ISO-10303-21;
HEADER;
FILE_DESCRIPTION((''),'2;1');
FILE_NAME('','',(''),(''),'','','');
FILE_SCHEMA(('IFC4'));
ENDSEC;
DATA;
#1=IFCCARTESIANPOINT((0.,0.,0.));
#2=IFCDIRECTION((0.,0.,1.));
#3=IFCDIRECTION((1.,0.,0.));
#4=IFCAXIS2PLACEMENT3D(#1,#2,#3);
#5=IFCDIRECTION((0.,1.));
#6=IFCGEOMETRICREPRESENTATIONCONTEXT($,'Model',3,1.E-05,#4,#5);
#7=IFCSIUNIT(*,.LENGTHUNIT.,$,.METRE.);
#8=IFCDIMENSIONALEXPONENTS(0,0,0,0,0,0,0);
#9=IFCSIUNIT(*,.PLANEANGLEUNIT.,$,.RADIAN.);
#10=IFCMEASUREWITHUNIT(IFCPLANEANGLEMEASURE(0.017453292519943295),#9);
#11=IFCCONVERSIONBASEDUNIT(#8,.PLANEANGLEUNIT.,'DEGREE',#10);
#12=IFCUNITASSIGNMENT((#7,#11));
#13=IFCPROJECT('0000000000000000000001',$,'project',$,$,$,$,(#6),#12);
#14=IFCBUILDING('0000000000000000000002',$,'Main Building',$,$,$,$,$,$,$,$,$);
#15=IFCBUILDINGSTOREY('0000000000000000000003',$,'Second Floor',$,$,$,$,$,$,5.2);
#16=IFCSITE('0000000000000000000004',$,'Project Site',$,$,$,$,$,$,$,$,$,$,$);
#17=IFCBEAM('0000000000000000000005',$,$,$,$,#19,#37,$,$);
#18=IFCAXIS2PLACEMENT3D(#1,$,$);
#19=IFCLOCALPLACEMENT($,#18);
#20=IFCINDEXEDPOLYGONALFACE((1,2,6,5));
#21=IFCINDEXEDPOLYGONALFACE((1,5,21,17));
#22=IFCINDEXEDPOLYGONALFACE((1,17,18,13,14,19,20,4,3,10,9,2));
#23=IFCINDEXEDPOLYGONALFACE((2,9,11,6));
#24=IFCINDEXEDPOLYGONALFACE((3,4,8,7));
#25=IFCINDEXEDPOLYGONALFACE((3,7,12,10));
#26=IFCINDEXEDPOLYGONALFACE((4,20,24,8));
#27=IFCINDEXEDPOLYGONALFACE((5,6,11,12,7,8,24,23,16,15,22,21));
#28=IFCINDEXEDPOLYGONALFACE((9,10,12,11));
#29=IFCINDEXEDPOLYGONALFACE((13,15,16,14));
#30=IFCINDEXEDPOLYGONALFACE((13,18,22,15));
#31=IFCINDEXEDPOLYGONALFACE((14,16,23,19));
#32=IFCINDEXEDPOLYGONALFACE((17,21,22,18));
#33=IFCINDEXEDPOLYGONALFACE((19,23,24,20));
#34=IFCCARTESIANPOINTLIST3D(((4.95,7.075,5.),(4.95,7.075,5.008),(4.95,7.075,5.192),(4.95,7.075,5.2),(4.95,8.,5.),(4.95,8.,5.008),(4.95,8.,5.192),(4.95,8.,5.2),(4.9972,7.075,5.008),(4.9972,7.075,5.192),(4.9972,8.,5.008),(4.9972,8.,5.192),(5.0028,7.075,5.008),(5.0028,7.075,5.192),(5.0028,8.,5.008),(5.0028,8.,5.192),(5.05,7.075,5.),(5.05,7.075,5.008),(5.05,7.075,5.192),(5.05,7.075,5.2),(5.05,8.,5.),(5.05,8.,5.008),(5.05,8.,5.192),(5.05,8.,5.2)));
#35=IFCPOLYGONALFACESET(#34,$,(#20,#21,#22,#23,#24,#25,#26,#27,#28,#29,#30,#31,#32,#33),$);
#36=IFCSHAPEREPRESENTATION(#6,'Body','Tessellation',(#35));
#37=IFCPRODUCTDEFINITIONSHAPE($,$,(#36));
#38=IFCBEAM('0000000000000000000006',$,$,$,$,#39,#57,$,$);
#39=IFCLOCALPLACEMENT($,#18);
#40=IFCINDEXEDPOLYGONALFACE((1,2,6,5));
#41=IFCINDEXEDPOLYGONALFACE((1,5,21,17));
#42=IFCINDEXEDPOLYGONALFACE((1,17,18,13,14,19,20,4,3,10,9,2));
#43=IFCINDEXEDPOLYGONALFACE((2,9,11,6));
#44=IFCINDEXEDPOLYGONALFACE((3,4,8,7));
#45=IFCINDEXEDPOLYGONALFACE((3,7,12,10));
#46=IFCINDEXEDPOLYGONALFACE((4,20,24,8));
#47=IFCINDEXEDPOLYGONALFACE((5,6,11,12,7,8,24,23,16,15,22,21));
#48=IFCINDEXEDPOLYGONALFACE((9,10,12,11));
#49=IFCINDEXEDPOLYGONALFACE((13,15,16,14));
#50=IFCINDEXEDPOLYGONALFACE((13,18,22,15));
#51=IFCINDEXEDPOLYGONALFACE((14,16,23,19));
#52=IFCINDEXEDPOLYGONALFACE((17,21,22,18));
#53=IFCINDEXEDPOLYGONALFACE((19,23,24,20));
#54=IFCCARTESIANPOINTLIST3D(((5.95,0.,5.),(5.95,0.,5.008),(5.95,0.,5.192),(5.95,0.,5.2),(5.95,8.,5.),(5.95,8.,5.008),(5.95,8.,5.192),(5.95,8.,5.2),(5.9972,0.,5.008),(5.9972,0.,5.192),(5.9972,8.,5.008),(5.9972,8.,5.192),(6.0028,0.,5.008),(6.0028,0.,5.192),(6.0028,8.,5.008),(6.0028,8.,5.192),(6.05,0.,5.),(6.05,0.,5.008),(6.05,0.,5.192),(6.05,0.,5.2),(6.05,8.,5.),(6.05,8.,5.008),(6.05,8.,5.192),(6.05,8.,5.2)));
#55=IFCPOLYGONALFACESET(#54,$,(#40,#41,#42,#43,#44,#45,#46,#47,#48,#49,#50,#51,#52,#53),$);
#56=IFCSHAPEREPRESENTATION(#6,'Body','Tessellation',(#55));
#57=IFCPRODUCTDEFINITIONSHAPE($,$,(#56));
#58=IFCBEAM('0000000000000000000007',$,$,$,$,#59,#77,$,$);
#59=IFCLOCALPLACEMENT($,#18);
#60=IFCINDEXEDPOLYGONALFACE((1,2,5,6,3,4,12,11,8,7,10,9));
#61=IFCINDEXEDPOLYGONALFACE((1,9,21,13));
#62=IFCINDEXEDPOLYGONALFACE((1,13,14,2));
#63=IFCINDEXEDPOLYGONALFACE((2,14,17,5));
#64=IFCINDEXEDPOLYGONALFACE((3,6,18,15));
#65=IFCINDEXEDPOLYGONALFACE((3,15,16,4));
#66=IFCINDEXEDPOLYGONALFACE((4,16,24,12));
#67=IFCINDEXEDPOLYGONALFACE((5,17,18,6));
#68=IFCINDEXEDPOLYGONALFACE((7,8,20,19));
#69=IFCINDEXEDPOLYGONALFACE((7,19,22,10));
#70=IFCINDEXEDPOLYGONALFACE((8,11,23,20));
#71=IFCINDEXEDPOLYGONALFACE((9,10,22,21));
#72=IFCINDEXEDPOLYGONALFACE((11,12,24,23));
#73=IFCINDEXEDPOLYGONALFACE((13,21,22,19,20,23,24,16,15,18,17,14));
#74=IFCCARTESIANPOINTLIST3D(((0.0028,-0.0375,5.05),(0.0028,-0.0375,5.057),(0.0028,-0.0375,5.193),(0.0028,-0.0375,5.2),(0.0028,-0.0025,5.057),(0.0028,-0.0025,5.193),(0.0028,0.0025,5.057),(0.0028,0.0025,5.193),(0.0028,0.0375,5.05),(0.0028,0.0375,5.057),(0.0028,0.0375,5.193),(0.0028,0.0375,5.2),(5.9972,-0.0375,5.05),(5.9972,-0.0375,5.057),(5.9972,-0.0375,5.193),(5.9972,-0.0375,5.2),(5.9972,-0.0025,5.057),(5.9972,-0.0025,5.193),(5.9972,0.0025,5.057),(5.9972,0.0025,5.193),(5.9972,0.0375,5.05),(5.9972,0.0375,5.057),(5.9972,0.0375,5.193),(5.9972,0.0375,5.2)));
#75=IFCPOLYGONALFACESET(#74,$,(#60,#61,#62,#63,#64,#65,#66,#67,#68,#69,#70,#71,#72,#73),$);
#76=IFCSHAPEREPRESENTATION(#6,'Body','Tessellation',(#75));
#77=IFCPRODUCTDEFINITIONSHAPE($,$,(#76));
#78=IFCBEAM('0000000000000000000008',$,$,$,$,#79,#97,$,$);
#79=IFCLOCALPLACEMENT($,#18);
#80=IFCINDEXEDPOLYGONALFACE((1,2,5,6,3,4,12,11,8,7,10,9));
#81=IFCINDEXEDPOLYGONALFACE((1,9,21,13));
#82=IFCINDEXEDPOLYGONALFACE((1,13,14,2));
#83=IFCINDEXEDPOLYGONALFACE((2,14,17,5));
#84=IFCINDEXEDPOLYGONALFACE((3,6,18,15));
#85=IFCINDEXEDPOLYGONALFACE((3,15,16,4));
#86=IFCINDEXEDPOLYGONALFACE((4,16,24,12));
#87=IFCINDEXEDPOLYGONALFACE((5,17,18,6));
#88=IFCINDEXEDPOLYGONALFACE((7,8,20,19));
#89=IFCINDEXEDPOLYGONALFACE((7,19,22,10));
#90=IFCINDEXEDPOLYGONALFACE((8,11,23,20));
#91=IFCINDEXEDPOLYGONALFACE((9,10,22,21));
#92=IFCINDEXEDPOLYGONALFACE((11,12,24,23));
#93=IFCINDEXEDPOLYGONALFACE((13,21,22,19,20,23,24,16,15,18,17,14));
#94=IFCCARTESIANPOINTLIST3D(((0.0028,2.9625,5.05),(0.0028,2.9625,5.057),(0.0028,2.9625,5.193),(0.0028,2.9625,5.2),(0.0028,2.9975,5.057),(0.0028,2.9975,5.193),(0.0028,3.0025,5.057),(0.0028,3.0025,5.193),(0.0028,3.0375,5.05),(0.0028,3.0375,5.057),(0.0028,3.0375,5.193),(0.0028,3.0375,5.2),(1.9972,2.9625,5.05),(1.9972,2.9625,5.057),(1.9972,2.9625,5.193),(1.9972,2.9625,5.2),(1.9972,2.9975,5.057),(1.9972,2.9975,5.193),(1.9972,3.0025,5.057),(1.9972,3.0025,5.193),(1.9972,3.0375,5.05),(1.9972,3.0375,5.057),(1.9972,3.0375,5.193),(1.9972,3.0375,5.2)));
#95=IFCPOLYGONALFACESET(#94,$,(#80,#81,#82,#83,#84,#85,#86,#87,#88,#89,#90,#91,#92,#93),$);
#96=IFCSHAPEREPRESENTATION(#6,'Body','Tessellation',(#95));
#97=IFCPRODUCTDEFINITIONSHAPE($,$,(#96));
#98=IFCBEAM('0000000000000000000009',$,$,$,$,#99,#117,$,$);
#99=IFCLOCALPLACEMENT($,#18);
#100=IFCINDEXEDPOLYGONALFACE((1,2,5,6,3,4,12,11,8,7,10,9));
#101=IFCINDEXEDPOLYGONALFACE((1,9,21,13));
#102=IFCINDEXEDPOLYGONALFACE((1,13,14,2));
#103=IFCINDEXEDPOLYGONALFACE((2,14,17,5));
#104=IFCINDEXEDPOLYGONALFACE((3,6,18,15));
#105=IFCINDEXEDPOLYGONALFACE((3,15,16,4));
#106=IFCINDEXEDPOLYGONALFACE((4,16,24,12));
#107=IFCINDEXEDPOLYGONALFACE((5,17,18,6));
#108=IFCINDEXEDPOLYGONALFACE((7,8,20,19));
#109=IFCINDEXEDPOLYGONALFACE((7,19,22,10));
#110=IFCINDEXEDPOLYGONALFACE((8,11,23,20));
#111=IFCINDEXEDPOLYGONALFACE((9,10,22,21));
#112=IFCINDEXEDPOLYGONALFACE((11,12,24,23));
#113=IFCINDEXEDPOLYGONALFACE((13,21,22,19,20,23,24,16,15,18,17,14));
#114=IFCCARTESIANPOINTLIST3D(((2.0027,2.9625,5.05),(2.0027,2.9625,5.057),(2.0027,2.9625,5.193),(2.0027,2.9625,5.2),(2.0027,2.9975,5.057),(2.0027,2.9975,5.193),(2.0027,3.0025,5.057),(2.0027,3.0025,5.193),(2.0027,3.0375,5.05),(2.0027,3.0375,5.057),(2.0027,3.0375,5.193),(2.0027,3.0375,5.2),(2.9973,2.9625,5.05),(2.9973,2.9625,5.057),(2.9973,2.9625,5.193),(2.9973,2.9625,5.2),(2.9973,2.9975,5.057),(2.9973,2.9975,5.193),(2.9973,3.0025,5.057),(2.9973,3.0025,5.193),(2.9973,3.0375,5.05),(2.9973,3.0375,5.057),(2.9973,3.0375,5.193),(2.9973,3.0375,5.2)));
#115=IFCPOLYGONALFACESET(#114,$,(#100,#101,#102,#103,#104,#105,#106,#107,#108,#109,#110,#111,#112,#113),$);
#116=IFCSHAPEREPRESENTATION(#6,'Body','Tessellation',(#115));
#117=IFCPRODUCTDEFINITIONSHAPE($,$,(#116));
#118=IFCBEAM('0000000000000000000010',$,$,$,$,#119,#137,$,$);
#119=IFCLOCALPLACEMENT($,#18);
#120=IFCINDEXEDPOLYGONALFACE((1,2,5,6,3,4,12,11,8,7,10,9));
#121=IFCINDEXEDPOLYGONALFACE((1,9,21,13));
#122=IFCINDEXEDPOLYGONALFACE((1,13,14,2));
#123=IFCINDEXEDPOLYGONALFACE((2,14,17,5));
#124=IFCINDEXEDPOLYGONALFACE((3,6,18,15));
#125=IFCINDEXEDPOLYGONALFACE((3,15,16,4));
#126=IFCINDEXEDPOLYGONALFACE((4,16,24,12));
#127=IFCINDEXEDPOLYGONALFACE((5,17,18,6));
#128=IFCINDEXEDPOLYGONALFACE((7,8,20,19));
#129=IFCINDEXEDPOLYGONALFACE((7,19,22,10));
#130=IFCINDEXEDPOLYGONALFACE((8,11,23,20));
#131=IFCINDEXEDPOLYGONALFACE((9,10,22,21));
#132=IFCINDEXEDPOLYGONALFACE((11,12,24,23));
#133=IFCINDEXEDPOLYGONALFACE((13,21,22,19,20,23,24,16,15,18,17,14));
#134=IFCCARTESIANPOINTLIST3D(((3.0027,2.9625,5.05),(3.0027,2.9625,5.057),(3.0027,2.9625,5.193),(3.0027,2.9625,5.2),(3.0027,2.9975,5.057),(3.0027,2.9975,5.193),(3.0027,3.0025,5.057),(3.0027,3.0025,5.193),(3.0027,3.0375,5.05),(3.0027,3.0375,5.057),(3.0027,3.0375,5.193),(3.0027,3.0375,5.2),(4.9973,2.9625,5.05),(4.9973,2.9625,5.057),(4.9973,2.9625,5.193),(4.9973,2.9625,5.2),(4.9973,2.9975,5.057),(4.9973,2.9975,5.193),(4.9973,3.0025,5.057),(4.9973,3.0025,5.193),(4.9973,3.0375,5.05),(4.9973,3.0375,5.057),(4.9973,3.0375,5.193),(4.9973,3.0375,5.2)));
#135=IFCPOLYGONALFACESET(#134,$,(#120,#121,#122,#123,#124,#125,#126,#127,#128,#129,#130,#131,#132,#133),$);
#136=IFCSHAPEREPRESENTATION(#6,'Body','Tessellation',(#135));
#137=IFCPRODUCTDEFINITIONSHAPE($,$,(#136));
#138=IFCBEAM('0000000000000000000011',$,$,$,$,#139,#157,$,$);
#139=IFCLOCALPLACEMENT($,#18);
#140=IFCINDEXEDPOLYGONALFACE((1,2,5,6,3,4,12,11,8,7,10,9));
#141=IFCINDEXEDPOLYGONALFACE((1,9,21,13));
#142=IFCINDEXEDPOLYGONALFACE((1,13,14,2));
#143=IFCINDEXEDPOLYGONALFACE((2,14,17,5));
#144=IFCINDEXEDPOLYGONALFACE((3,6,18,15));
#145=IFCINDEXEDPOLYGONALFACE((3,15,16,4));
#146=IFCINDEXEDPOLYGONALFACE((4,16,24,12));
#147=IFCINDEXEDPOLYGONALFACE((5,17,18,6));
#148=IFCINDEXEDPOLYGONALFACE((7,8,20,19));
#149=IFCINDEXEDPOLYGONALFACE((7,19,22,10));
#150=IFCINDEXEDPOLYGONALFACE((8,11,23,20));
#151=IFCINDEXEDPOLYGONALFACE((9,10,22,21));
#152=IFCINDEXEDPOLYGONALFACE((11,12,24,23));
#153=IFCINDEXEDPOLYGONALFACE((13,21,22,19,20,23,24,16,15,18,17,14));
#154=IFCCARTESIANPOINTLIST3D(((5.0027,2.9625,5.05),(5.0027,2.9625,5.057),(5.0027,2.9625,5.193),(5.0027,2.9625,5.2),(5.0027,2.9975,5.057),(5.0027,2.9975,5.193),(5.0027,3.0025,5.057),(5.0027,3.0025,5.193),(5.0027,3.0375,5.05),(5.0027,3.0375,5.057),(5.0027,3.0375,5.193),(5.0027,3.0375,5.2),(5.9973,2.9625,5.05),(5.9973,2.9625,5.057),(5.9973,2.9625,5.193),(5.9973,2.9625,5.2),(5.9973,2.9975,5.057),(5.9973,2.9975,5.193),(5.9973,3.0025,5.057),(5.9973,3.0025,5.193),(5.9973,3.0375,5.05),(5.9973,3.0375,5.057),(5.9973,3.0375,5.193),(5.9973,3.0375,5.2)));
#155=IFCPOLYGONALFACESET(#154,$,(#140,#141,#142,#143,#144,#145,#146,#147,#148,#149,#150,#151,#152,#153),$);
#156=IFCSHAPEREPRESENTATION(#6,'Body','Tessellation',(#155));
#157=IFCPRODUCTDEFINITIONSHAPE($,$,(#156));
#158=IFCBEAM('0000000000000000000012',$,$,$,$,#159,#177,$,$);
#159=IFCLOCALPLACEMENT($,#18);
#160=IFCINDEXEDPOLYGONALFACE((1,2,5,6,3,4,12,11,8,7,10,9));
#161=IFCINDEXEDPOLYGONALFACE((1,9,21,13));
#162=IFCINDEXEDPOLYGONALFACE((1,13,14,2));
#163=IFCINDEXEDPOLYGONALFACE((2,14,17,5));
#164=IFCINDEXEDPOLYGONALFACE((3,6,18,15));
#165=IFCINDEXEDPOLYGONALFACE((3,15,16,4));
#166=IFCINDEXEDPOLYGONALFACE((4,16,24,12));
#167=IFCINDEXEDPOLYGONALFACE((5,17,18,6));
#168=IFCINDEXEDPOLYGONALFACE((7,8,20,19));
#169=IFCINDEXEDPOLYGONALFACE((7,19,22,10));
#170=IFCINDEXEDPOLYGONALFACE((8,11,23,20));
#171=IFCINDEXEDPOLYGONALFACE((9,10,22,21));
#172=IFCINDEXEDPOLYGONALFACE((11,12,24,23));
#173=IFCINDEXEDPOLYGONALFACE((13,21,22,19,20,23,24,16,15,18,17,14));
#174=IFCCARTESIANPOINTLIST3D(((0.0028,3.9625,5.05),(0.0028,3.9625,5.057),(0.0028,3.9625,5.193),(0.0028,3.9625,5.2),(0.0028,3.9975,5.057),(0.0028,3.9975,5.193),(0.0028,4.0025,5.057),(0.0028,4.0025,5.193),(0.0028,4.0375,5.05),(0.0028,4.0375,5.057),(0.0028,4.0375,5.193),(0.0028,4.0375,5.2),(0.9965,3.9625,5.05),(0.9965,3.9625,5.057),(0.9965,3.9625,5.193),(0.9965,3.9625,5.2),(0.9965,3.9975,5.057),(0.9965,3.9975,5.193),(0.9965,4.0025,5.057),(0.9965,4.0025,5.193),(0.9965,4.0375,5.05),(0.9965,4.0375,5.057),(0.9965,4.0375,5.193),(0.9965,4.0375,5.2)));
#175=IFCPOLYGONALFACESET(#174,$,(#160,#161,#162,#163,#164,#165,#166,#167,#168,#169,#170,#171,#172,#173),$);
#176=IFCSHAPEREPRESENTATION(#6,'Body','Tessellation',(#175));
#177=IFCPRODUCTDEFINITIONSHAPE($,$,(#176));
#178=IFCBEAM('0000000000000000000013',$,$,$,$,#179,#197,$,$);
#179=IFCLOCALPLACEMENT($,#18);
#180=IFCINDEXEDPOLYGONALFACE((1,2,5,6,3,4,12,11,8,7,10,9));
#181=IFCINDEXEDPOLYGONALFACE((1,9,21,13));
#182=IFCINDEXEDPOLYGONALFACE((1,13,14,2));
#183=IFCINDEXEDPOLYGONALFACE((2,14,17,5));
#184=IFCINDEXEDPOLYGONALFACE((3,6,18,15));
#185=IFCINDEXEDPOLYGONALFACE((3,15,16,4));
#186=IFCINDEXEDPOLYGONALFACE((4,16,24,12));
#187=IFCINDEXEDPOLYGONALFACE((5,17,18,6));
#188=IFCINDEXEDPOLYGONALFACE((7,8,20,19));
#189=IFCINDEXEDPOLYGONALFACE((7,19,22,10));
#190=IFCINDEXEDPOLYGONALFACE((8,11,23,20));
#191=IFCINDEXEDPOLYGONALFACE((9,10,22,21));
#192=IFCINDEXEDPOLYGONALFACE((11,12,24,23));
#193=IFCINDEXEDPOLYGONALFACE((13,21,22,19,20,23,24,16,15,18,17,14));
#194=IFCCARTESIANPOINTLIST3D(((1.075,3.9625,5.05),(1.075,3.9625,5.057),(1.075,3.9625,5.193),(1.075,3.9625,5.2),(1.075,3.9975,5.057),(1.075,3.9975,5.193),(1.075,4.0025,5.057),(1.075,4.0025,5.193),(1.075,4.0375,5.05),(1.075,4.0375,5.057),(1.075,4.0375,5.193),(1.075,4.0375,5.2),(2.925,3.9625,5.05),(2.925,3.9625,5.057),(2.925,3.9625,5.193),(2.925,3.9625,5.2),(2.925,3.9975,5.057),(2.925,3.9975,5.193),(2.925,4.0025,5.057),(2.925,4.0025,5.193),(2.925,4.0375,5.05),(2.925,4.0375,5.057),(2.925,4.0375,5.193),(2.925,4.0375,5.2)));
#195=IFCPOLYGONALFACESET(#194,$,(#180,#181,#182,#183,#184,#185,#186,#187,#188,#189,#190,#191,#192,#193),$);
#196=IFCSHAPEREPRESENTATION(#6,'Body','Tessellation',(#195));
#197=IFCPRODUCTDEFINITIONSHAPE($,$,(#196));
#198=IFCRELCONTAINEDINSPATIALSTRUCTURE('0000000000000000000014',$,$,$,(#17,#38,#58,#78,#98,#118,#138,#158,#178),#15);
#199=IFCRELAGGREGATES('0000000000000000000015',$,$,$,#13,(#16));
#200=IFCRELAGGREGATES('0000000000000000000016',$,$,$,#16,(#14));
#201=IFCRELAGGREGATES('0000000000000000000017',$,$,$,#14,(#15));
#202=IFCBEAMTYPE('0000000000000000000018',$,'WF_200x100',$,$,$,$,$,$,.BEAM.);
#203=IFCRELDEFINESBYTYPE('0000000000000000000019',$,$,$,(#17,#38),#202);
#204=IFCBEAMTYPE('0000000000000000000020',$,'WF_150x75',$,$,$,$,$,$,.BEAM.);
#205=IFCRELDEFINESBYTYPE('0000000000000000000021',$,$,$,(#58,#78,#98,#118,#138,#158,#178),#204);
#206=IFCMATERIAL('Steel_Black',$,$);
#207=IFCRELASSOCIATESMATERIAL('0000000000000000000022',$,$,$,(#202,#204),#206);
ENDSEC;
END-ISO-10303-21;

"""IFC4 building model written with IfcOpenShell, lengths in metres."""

from ifc_helpers import new_model, entity, si_unit, converted_unit, direction, frame, frame_2d, origin_with_axes, origin_2d, place, context, project, spatial, i_section, extrude, material, material_profile, profile_set, type_object, element, save


model = new_model("IFC4")

# Units and contexts
model_context = context("Model", 3, precision=1e-05, world=origin_with_axes(), true_north=direction((0.0, 1.0)))
ifc_project = project(units=[si_unit("LENGTHUNIT", "METRE"), converted_unit("PLANEANGLEUNIT", "DEGREE", entity("IfcPlaneAngleMeasure", 0.017453292519943295), si_unit("PLANEANGLEUNIT", "RADIAN"), dimensions=[0, 0, 0, 0, 0, 0, 0])], contexts=[model_context])

# Site, building, storey
site = spatial("IfcSite", under=ifc_project, Name="Project Site")
building = spatial("IfcBuilding", under=site, Name="Main Building")
storey = spatial("IfcBuildingStorey", under=building, Name="Second Floor", Elevation=5.2)

# Beams
ifc_material = material(Name="Steel_Black")
ifc_material_profile_1 = material_profile(ifc_material, i_section(OverallWidth=0.1, OverallDepth=0.2, WebThickness=0.0055, FlangeThickness=0.008, at=origin_2d()), Name="WF_200x100")
ifc_profile_set_1 = profile_set([ifc_material_profile_1], Name="WF_200x100")
beam_type_1 = type_object("IfcBeamType", Name="WF_200x100", PredefinedType="BEAM", material=ifc_profile_set_1)
beam_1_placement = place(None, frame((5.0, 7.075, 5.0), z_axis=(0.0, 0.0, 1.0), x_axis=(0.0, 1.0, 0.0)))
element("IfcBeam", 1, at=beam_1_placement, inside=storey, type_object=beam_type_1, context=model_context, shape_type="SweptSolid", body=[
    extrude(i_section(OverallWidth=0.1, OverallDepth=0.2, WebThickness=0.0055, FlangeThickness=0.008, at=frame_2d((0.0, 0.1))), frame((0.0, 0.0, 0.0), z_axis=(1.0, 0.0, 0.0), x_axis=(0.0, 1.0, 0.0)), (0.0, 0.0, 1.0), 0.925),
])
beam_2_placement = place(None, frame((6.0, 0.0, 5.0), z_axis=(0.0, 0.0, 1.0), x_axis=(0.0, 1.0, 0.0)))
element("IfcBeam", 2, at=beam_2_placement, inside=storey, type_object=beam_type_1, context=model_context, shape_type="SweptSolid", body=[
    extrude(i_section(OverallWidth=0.1, OverallDepth=0.2, WebThickness=0.0055, FlangeThickness=0.008, at=frame_2d((0.0, 0.1))), frame((0.0, 0.0, 0.0), z_axis=(1.0, 0.0, 0.0), x_axis=(0.0, 1.0, 0.0)), (0.0, 0.0, 1.0), 8.0),
])
ifc_material_profile_2 = material_profile(ifc_material, i_section(OverallWidth=0.075, OverallDepth=0.15, WebThickness=0.005, FlangeThickness=0.007, at=origin_2d()), Name="WF_150x75")
ifc_profile_set_2 = profile_set([ifc_material_profile_2], Name="WF_150x75")
beam_type_2 = type_object("IfcBeamType", Name="WF_150x75", PredefinedType="BEAM", material=ifc_profile_set_2)
beam_3_placement = place(None, frame((0.0027, 0.0, 5.05), z_axis=(0.0, 0.0, 1.0), x_axis=(1.0, 0.0, 0.0)))
element("IfcBeam", 3, at=beam_3_placement, inside=storey, type_object=beam_type_2, context=model_context, shape_type="SweptSolid", body=[
    extrude(i_section(OverallWidth=0.075, OverallDepth=0.15, WebThickness=0.005, FlangeThickness=0.007, at=frame_2d((0.0, 0.075))), frame((0.0, 0.0, 0.0), z_axis=(1.0, 0.0, 0.0), x_axis=(0.0, 1.0, 0.0)), (0.0, 0.0, 1.0), 5.9945),
])
beam_4_placement = place(None, frame((0.0027, 3.0, 5.05), z_axis=(0.0, 0.0, 1.0), x_axis=(1.0, 0.0, 0.0)))
element("IfcBeam", 4, at=beam_4_placement, inside=storey, type_object=beam_type_2, context=model_context, shape_type="SweptSolid", body=[
    extrude(i_section(OverallWidth=0.075, OverallDepth=0.15, WebThickness=0.005, FlangeThickness=0.007, at=frame_2d((0.0, 0.075))), frame((0.0, 0.0, 0.0), z_axis=(1.0, 0.0, 0.0), x_axis=(0.0, 1.0, 0.0)), (0.0, 0.0, 1.0), 1.9945),
])
beam_5_placement = place(None, frame((2.0027, 3.0, 5.05), z_axis=(0.0, 0.0, 1.0), x_axis=(1.0, 0.0, 0.0)))
element("IfcBeam", 5, at=beam_5_placement, inside=storey, type_object=beam_type_2, context=model_context, shape_type="SweptSolid", body=[
    extrude(i_section(OverallWidth=0.075, OverallDepth=0.15, WebThickness=0.005, FlangeThickness=0.007, at=frame_2d((0.0, 0.075))), frame((0.0, 0.0, 0.0), z_axis=(1.0, 0.0, 0.0), x_axis=(0.0, 1.0, 0.0)), (0.0, 0.0, 1.0), 0.9946),
])
beam_6_placement = place(None, frame((3.0027, 3.0, 5.05), z_axis=(0.0, 0.0, 1.0), x_axis=(1.0, 0.0, 0.0)))
element("IfcBeam", 6, at=beam_6_placement, inside=storey, type_object=beam_type_2, context=model_context, shape_type="SweptSolid", body=[
    extrude(i_section(OverallWidth=0.075, OverallDepth=0.15, WebThickness=0.005, FlangeThickness=0.007, at=frame_2d((0.0, 0.075))), frame((0.0, 0.0, 0.0), z_axis=(1.0, 0.0, 0.0), x_axis=(0.0, 1.0, 0.0)), (0.0, 0.0, 1.0), 1.9946),
])
beam_7_placement = place(None, frame((5.0027, 3.0, 5.05), z_axis=(0.0, 0.0, 1.0), x_axis=(1.0, 0.0, 0.0)))
element("IfcBeam", 7, at=beam_7_placement, inside=storey, type_object=beam_type_2, context=model_context, shape_type="SweptSolid", body=[
    extrude(i_section(OverallWidth=0.075, OverallDepth=0.15, WebThickness=0.005, FlangeThickness=0.007, at=frame_2d((0.0, 0.075))), frame((0.0, 0.0, 0.0), z_axis=(1.0, 0.0, 0.0), x_axis=(0.0, 1.0, 0.0)), (0.0, 0.0, 1.0), 0.9946),
])
beam_8_placement = place(None, frame((0.0027, 4.0, 5.05), z_axis=(0.0, 0.0, 1.0), x_axis=(1.0, 0.0, 0.0)))
element("IfcBeam", 8, at=beam_8_placement, inside=storey, type_object=beam_type_2, context=model_context, shape_type="SweptSolid", body=[
    extrude(i_section(OverallWidth=0.075, OverallDepth=0.15, WebThickness=0.005, FlangeThickness=0.007, at=frame_2d((0.0, 0.075))), frame((0.0, 0.0, 0.0), z_axis=(1.0, 0.0, 0.0), x_axis=(0.0, 1.0, 0.0)), (0.0, 0.0, 1.0), 0.9938),
])
for number, where, z_axis, x_axis in (
    (9, (1.075, 4.0, 5.05), (0.0, 0.0, 1.0), (1.0, 0.0, 0.0)),
):
    element("IfcBeam", number, at=place(None, frame(where, z_axis=z_axis, x_axis=x_axis)), inside=storey, type_object=beam_type_2, context=model_context, shape_type="SweptSolid", body=[
        extrude(i_section(OverallWidth=0.075, OverallDepth=0.15, WebThickness=0.005, FlangeThickness=0.007, at=frame_2d((0.0, 0.075))), frame((0.0, 0.0, 0.0), z_axis=(1.0, 0.0, 0.0), x_axis=(0.0, 1.0, 0.0)), (0.0, 0.0, 1.0), 1.85),
    ])

save(model, "model.ifc")
